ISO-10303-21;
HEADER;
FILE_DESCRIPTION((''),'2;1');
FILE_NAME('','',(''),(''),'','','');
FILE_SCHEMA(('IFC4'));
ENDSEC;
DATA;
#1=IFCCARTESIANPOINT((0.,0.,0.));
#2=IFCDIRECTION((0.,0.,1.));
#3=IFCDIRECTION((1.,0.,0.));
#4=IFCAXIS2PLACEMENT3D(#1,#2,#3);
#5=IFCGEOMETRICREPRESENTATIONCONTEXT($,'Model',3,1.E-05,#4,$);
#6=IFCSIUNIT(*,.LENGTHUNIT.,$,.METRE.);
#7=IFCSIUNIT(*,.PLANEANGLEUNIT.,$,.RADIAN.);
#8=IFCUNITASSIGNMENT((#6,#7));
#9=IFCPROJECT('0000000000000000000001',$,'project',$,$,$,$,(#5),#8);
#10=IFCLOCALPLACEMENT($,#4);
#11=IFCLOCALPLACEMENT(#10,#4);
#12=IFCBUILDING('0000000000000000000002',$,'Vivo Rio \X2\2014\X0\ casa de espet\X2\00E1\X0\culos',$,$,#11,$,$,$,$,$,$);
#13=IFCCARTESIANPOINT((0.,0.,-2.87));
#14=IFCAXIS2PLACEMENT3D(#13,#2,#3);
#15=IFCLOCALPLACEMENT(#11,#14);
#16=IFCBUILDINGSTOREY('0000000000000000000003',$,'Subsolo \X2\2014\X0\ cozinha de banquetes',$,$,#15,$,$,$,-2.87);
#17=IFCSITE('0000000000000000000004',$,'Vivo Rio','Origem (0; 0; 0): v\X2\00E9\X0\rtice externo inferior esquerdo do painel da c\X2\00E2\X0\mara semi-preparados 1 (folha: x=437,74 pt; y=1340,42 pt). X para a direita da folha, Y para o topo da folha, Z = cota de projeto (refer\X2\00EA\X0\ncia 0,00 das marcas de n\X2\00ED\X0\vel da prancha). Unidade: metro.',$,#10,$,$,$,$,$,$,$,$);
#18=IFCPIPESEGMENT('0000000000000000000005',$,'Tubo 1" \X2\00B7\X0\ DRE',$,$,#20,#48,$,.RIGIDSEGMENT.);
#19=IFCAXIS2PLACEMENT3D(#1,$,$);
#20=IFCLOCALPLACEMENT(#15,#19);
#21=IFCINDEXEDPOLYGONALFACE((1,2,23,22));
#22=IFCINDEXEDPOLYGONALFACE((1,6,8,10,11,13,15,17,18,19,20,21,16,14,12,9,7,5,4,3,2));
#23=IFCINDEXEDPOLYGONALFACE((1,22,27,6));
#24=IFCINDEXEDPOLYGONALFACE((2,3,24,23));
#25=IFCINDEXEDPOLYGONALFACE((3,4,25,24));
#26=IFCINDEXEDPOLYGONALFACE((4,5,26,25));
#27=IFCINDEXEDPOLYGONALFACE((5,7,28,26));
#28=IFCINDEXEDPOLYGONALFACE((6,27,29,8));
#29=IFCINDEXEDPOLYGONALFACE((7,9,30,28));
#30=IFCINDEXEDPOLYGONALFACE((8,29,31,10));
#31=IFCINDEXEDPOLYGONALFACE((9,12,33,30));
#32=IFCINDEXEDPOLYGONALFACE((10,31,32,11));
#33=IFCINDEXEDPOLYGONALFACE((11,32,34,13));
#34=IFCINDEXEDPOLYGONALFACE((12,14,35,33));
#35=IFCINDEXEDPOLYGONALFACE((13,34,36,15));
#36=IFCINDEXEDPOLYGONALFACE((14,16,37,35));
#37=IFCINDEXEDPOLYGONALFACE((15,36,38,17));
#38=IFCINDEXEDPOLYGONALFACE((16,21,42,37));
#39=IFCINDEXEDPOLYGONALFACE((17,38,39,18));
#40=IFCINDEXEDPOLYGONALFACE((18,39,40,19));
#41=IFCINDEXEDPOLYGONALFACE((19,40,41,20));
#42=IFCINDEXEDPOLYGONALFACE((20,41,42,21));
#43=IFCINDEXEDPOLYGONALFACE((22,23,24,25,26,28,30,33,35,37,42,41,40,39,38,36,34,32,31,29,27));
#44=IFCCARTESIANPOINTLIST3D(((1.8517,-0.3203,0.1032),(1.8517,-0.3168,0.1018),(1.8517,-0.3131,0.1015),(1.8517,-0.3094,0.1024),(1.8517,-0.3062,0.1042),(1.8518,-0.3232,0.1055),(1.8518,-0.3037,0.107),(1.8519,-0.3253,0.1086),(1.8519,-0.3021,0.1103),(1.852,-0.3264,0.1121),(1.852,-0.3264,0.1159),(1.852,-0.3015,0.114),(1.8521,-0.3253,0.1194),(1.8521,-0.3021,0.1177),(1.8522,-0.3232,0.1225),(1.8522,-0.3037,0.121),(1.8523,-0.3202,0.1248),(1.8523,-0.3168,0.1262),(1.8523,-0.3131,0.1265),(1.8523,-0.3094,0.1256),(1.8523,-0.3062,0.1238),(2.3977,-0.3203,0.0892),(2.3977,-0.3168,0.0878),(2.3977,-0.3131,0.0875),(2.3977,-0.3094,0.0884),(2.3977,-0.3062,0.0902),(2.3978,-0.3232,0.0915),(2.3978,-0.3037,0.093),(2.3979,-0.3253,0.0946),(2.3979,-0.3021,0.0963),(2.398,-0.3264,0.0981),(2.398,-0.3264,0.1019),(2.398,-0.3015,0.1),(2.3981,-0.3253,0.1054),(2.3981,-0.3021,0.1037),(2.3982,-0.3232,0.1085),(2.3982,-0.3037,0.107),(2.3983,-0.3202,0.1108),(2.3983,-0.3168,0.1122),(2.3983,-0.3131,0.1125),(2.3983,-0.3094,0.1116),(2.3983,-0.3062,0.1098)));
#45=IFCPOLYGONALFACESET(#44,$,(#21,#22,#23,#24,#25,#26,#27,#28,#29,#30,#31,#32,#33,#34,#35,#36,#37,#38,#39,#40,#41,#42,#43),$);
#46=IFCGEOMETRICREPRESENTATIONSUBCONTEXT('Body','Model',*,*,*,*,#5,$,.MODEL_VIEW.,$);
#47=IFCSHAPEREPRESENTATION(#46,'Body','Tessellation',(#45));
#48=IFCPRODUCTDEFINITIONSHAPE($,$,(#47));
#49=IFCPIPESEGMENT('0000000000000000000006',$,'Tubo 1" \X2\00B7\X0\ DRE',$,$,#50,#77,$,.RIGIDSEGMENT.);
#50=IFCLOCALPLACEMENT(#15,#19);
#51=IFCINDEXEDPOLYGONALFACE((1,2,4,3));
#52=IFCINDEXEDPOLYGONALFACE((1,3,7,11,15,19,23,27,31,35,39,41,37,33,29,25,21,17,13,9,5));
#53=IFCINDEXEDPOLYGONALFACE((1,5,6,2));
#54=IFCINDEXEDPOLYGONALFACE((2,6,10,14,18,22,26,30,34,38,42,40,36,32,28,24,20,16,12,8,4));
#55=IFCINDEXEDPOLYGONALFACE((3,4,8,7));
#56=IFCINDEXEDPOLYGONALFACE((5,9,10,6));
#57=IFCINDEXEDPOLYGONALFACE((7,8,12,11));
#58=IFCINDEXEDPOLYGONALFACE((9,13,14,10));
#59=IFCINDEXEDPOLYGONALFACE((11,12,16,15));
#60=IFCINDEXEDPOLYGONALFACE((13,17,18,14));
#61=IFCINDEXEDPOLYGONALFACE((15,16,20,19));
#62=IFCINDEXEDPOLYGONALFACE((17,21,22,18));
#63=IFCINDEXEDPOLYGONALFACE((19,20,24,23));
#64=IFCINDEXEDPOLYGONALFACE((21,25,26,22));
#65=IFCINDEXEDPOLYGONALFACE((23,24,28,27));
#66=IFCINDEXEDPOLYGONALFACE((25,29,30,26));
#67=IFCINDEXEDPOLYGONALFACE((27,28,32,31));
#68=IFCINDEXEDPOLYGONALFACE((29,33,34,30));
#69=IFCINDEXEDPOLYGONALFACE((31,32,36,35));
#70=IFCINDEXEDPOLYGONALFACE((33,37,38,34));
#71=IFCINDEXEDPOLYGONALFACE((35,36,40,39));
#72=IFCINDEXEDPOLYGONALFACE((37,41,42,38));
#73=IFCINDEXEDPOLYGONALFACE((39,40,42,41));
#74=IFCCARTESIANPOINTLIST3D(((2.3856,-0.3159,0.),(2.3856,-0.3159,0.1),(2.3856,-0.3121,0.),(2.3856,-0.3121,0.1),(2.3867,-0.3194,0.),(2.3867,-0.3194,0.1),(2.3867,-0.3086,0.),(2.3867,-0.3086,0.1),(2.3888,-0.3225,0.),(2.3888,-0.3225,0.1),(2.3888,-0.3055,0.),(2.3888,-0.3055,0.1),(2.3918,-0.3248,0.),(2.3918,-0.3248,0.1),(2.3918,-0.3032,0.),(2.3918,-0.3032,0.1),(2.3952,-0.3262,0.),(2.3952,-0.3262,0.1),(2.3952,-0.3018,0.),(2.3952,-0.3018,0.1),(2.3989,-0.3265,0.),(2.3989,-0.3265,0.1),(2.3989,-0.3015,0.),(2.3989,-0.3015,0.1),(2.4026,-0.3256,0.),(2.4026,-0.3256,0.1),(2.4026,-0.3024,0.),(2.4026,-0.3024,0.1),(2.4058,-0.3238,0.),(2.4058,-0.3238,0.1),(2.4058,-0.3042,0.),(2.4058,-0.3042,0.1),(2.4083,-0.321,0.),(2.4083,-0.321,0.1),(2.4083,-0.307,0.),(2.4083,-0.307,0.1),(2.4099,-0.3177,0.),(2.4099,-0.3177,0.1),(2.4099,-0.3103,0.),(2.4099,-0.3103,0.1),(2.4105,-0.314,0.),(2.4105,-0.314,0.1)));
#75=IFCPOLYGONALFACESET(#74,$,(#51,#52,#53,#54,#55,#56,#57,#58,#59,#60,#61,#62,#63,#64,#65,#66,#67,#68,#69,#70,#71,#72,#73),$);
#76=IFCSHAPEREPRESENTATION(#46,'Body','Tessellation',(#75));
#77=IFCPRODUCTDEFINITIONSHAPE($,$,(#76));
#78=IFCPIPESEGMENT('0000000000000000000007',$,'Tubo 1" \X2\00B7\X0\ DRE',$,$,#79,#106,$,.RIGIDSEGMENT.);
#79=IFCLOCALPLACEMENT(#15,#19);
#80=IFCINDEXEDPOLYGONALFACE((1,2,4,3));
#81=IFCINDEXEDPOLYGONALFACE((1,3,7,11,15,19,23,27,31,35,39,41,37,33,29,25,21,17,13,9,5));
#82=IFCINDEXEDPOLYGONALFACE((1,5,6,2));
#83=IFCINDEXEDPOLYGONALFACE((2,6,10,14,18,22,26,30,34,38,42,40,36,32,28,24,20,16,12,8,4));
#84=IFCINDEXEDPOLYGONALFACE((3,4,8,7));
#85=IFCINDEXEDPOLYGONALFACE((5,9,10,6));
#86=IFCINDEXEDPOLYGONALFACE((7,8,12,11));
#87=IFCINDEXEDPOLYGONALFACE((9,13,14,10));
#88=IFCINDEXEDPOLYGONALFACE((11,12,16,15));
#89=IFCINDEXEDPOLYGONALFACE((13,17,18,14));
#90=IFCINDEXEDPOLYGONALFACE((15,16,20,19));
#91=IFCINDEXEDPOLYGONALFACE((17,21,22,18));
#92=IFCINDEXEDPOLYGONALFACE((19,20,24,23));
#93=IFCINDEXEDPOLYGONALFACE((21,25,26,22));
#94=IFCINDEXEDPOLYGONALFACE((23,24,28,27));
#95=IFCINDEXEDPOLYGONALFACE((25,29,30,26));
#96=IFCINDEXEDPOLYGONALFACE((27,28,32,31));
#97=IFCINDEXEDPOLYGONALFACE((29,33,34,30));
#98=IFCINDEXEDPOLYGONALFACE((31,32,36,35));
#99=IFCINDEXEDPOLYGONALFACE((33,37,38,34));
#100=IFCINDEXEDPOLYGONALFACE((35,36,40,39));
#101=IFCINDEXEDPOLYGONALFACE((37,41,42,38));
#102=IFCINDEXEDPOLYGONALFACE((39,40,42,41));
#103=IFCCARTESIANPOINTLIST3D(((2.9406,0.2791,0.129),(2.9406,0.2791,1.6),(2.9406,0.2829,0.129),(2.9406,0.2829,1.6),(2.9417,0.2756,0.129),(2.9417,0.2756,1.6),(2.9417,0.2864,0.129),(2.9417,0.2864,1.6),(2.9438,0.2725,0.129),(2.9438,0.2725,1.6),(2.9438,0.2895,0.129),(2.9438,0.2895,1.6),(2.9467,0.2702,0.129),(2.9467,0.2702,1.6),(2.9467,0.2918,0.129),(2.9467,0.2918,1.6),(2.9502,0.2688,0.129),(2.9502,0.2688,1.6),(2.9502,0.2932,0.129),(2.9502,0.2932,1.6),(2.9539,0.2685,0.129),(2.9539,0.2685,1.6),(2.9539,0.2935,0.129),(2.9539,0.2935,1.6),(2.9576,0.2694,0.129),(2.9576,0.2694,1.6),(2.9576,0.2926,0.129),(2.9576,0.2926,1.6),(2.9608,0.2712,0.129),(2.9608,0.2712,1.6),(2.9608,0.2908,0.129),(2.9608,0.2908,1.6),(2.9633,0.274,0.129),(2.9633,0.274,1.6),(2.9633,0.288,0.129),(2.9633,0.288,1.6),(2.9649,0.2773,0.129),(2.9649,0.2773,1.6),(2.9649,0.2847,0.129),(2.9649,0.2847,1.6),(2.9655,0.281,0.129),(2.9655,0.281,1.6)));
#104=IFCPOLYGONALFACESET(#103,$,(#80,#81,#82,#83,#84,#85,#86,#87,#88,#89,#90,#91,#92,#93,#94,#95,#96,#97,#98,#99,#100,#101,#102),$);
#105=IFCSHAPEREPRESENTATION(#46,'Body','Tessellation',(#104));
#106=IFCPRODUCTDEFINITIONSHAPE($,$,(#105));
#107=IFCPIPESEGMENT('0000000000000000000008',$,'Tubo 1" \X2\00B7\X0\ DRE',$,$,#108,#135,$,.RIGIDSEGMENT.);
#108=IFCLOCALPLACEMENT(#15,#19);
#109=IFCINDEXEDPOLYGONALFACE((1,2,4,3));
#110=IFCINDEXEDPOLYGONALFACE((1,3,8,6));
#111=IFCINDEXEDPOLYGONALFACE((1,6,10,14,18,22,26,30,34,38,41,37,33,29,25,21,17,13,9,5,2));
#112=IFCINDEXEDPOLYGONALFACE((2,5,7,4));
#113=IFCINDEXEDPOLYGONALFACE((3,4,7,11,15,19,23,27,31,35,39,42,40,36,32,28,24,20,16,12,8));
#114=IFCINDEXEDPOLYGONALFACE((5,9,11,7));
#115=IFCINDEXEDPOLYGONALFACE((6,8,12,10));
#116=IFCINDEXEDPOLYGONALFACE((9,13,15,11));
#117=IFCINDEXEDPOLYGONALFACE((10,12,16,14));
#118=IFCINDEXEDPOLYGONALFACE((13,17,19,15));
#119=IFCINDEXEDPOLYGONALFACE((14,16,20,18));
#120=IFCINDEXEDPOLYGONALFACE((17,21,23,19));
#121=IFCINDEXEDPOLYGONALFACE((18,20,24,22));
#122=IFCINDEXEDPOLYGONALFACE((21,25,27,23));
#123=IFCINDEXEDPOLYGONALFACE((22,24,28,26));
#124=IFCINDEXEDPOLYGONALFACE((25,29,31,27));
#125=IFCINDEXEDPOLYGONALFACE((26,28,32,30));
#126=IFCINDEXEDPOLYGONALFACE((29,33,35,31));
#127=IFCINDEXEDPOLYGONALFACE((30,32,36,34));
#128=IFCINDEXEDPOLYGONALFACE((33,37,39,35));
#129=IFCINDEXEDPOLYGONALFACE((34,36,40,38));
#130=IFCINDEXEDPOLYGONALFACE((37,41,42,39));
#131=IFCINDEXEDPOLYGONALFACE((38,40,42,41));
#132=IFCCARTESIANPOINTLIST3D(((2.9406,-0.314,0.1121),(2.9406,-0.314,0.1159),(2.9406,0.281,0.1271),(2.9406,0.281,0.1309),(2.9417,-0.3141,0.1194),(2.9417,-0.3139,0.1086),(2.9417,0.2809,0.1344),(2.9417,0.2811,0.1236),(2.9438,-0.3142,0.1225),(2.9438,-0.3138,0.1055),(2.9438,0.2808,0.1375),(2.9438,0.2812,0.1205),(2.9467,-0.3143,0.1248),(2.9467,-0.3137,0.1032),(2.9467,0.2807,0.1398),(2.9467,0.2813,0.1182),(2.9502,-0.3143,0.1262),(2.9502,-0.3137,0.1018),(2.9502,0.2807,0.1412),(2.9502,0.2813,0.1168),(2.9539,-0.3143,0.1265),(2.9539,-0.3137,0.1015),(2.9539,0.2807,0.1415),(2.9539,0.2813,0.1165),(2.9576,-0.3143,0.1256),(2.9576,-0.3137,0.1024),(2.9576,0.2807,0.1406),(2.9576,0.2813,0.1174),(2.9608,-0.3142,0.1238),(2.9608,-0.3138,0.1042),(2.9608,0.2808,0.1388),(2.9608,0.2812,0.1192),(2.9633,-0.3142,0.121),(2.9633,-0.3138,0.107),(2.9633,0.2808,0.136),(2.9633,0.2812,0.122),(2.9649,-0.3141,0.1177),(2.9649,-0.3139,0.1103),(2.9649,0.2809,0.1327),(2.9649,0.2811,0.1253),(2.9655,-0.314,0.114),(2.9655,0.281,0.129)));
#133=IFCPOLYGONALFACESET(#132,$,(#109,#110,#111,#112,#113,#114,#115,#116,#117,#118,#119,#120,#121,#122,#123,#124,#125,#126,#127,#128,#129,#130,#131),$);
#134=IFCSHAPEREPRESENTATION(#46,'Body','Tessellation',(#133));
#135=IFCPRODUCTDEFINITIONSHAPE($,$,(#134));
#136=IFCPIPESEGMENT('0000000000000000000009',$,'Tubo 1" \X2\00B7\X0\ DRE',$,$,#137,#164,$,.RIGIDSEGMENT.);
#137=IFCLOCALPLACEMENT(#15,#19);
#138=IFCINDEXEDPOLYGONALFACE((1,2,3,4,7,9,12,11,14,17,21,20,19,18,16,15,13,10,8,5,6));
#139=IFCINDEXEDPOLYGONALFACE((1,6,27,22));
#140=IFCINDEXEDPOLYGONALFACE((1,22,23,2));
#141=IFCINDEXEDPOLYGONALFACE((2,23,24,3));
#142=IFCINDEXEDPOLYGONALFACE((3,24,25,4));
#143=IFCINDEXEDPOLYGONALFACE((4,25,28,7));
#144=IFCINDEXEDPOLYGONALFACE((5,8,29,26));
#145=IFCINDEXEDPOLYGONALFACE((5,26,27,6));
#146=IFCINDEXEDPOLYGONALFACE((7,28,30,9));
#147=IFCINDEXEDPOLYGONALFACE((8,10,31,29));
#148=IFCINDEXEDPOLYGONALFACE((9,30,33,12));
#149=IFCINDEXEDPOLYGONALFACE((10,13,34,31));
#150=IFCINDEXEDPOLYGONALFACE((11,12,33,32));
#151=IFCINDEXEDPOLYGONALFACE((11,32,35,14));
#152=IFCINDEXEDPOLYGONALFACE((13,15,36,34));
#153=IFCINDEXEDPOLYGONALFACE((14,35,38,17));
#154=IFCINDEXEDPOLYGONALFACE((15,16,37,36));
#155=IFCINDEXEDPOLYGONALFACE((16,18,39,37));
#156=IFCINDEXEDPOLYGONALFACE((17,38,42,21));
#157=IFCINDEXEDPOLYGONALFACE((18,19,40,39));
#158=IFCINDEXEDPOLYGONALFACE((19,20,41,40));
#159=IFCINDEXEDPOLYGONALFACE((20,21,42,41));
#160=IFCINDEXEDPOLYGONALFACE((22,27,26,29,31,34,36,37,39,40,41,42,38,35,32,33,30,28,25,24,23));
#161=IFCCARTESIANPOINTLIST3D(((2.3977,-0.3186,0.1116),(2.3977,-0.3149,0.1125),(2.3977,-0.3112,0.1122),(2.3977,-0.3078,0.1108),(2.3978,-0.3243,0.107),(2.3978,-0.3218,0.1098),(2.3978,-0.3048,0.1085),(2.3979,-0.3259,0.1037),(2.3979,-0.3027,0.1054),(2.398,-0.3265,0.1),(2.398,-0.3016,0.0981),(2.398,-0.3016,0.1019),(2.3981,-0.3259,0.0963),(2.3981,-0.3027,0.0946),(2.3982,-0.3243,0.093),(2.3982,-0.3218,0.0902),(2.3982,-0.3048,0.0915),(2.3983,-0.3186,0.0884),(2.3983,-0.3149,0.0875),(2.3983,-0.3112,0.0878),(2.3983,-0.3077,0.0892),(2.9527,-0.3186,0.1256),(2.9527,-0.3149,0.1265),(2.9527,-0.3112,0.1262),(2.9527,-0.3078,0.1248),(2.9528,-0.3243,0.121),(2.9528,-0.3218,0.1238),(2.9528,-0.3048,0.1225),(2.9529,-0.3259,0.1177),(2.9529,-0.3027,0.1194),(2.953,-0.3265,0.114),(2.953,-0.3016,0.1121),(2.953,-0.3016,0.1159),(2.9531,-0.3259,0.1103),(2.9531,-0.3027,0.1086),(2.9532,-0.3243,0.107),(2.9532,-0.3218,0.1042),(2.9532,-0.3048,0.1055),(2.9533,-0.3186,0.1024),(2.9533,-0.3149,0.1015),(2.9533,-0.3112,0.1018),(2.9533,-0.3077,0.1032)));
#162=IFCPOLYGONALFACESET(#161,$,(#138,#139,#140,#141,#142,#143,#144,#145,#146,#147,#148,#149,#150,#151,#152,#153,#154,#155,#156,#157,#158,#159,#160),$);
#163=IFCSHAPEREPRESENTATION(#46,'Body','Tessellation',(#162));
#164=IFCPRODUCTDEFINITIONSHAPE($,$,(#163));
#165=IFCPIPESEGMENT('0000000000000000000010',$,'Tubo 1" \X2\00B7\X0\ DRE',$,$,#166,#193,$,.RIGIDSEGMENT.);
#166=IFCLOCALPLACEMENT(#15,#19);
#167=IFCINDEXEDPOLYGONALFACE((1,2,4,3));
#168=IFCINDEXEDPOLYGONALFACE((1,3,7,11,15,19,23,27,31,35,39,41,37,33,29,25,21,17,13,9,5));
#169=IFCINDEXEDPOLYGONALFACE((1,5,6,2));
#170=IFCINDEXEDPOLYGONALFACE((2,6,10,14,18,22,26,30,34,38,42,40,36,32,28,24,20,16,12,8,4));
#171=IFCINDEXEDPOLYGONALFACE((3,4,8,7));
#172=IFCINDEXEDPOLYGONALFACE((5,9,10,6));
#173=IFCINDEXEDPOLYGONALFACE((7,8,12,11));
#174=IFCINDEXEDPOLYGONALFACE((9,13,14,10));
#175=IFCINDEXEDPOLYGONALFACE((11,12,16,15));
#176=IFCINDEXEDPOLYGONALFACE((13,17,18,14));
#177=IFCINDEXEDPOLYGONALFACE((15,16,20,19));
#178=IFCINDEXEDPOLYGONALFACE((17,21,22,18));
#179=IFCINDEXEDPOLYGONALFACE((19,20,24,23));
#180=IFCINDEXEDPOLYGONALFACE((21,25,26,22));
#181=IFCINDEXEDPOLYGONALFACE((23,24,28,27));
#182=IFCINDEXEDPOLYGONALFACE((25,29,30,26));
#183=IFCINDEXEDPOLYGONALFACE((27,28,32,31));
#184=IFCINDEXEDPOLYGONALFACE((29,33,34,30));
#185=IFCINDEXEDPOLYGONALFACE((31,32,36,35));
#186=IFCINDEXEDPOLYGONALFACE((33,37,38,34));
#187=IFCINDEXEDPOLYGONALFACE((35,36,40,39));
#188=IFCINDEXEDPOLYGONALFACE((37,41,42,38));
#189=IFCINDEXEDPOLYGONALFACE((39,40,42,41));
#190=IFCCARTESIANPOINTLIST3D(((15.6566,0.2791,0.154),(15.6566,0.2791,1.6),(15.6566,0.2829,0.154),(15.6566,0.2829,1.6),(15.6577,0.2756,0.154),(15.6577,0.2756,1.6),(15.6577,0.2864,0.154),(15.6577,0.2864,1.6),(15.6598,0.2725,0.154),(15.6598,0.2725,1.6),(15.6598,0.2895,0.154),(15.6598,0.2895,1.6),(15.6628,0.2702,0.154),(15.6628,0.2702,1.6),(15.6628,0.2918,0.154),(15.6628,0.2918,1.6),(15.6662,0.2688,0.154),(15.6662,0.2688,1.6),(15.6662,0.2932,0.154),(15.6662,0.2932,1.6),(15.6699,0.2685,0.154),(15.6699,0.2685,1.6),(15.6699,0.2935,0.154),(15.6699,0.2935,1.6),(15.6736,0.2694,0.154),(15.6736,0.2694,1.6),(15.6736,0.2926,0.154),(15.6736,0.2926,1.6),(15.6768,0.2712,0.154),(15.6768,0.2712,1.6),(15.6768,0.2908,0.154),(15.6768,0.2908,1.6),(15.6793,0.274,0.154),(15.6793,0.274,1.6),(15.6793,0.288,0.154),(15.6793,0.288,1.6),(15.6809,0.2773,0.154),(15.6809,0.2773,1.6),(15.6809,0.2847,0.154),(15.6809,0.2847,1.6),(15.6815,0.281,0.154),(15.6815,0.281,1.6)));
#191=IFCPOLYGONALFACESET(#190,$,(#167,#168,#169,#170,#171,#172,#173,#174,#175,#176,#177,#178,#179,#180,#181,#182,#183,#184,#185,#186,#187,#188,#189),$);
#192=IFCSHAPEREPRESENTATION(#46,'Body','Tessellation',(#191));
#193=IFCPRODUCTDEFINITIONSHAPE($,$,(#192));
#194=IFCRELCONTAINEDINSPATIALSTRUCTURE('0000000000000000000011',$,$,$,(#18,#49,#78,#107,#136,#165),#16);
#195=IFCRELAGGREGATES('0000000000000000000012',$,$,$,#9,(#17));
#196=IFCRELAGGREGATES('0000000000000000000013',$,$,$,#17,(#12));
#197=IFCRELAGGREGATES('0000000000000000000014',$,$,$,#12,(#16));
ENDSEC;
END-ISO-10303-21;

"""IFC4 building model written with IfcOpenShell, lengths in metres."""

from ifc_helpers import new_model, si_unit, frame, origin_with_axes, origin_2d, place, context, subcontext, project, spatial, circle, extrude, element, save


model = new_model("IFC4")

# Units and contexts
model_context = context("Model", 3, precision=1e-05, world=origin_with_axes())
body_context = subcontext(model_context, "Body", "Model", "MODEL_VIEW")
ifc_project = project(units=[si_unit("LENGTHUNIT", "METRE"), si_unit("PLANEANGLEUNIT", "RADIAN")], contexts=[model_context])

# Site, building, storey
site_placement = place(None, origin_with_axes())
site = spatial("IfcSite", under=ifc_project, at=site_placement, Name="Vivo Rio", Description="Origem (0; 0; 0): vértice externo inferior esquerdo do painel da câmara semi-preparados 1 (folha: x=437,74 pt; y=1340,42 pt). X para a direita da folha, Y para o topo da folha, Z = cota de projeto (referência 0,00 das marcas de nível da prancha). Unidade: metro.")
building_placement = place(site_placement, origin_with_axes())
building = spatial("IfcBuilding", under=site, at=building_placement, Name="Vivo Rio — casa de espetáculos")
storey_placement = place(building_placement, frame((0.0, 0.0, -2.87), z_axis=(0.0, 0.0, 1.0), x_axis=(1.0, 0.0, 0.0)))
storey = spatial("IfcBuildingStorey", under=building, at=storey_placement, Name="Subsolo — cozinha de banquetes", Elevation=-2.87)

# Pipe segments
pipe_segment_1_placement = place(storey_placement, origin_with_axes())
element("IfcPipeSegment", 1, at=pipe_segment_1_placement, inside=storey, Name="Tubo 1\" · DRE", PredefinedType="RIGIDSEGMENT", context=body_context, shape_type="SweptSolid", body=[
    extrude(circle(Radius=0.0125, at=origin_2d()), frame((1.852, -0.314, 0.114), z_axis=(0.999671, 0.0, -0.025633), x_axis=(0.0, 1.0, 0.0)), (0.0, 0.0, 1.0), 0.5462),
])
pipe_segment_2_placement = place(storey_placement, origin_with_axes())
element("IfcPipeSegment", 2, at=pipe_segment_2_placement, inside=storey, Name="Tubo 1\" · DRE", PredefinedType="RIGIDSEGMENT", context=body_context, shape_type="SweptSolid", body=[
    extrude(circle(Radius=0.0125, at=origin_2d()), frame((2.398, -0.314, 0.1), z_axis=(0.0, 0.0, -1.0), x_axis=(1.0, 0.0, 0.0)), (0.0, 0.0, 1.0), 0.1),
])
pipe_segment_3_placement = place(storey_placement, origin_with_axes())
element("IfcPipeSegment", 3, at=pipe_segment_3_placement, inside=storey, Name="Tubo 1\" · DRE", PredefinedType="RIGIDSEGMENT", context=body_context, shape_type="SweptSolid", body=[
    extrude(circle(Radius=0.0125, at=origin_2d()), frame((2.953, 0.281, 1.6), z_axis=(0.0, 0.0, -1.0), x_axis=(1.0, 0.0, 0.0)), (0.0, 0.0, 1.0), 1.471),
])
pipe_segment_4_placement = place(storey_placement, origin_with_axes())
element("IfcPipeSegment", 4, at=pipe_segment_4_placement, inside=storey, Name="Tubo 1\" · DRE", PredefinedType="RIGIDSEGMENT", context=body_context, shape_type="SweptSolid", body=[
    extrude(circle(Radius=0.0125, at=origin_2d()), frame((2.953, 0.281, 0.129), z_axis=(0.0, -0.999682, -0.025202), x_axis=(1.0, 0.0, 0.0)), (0.0, 0.0, 1.0), 0.5952),
])
pipe_segment_5_placement = place(storey_placement, origin_with_axes())
element("IfcPipeSegment", 5, at=pipe_segment_5_placement, inside=storey, Name="Tubo 1\" · DRE", PredefinedType="RIGIDSEGMENT", context=body_context, shape_type="SweptSolid", body=[
    extrude(circle(Radius=0.0125, at=origin_2d()), frame((2.953, -0.314, 0.114), z_axis=(-0.999682, 0.0, -0.025217), x_axis=(0.0, -1.0, 0.0)), (0.0, 0.0, 1.0), 0.5552),
])
pipe_segment_6_placement = place(storey_placement, origin_with_axes())
element("IfcPipeSegment", 6, at=pipe_segment_6_placement, inside=storey, Name="Tubo 1\" · DRE", PredefinedType="RIGIDSEGMENT", context=body_context, shape_type="SweptSolid", body=[
    extrude(circle(Radius=0.0125, at=origin_2d()), frame((15.669, 0.281, 1.6), z_axis=(0.0, 0.0, -1.0), x_axis=(1.0, 0.0, 0.0)), (0.0, 0.0, 1.0), 1.446),
])

save(model, "model.ifc")
